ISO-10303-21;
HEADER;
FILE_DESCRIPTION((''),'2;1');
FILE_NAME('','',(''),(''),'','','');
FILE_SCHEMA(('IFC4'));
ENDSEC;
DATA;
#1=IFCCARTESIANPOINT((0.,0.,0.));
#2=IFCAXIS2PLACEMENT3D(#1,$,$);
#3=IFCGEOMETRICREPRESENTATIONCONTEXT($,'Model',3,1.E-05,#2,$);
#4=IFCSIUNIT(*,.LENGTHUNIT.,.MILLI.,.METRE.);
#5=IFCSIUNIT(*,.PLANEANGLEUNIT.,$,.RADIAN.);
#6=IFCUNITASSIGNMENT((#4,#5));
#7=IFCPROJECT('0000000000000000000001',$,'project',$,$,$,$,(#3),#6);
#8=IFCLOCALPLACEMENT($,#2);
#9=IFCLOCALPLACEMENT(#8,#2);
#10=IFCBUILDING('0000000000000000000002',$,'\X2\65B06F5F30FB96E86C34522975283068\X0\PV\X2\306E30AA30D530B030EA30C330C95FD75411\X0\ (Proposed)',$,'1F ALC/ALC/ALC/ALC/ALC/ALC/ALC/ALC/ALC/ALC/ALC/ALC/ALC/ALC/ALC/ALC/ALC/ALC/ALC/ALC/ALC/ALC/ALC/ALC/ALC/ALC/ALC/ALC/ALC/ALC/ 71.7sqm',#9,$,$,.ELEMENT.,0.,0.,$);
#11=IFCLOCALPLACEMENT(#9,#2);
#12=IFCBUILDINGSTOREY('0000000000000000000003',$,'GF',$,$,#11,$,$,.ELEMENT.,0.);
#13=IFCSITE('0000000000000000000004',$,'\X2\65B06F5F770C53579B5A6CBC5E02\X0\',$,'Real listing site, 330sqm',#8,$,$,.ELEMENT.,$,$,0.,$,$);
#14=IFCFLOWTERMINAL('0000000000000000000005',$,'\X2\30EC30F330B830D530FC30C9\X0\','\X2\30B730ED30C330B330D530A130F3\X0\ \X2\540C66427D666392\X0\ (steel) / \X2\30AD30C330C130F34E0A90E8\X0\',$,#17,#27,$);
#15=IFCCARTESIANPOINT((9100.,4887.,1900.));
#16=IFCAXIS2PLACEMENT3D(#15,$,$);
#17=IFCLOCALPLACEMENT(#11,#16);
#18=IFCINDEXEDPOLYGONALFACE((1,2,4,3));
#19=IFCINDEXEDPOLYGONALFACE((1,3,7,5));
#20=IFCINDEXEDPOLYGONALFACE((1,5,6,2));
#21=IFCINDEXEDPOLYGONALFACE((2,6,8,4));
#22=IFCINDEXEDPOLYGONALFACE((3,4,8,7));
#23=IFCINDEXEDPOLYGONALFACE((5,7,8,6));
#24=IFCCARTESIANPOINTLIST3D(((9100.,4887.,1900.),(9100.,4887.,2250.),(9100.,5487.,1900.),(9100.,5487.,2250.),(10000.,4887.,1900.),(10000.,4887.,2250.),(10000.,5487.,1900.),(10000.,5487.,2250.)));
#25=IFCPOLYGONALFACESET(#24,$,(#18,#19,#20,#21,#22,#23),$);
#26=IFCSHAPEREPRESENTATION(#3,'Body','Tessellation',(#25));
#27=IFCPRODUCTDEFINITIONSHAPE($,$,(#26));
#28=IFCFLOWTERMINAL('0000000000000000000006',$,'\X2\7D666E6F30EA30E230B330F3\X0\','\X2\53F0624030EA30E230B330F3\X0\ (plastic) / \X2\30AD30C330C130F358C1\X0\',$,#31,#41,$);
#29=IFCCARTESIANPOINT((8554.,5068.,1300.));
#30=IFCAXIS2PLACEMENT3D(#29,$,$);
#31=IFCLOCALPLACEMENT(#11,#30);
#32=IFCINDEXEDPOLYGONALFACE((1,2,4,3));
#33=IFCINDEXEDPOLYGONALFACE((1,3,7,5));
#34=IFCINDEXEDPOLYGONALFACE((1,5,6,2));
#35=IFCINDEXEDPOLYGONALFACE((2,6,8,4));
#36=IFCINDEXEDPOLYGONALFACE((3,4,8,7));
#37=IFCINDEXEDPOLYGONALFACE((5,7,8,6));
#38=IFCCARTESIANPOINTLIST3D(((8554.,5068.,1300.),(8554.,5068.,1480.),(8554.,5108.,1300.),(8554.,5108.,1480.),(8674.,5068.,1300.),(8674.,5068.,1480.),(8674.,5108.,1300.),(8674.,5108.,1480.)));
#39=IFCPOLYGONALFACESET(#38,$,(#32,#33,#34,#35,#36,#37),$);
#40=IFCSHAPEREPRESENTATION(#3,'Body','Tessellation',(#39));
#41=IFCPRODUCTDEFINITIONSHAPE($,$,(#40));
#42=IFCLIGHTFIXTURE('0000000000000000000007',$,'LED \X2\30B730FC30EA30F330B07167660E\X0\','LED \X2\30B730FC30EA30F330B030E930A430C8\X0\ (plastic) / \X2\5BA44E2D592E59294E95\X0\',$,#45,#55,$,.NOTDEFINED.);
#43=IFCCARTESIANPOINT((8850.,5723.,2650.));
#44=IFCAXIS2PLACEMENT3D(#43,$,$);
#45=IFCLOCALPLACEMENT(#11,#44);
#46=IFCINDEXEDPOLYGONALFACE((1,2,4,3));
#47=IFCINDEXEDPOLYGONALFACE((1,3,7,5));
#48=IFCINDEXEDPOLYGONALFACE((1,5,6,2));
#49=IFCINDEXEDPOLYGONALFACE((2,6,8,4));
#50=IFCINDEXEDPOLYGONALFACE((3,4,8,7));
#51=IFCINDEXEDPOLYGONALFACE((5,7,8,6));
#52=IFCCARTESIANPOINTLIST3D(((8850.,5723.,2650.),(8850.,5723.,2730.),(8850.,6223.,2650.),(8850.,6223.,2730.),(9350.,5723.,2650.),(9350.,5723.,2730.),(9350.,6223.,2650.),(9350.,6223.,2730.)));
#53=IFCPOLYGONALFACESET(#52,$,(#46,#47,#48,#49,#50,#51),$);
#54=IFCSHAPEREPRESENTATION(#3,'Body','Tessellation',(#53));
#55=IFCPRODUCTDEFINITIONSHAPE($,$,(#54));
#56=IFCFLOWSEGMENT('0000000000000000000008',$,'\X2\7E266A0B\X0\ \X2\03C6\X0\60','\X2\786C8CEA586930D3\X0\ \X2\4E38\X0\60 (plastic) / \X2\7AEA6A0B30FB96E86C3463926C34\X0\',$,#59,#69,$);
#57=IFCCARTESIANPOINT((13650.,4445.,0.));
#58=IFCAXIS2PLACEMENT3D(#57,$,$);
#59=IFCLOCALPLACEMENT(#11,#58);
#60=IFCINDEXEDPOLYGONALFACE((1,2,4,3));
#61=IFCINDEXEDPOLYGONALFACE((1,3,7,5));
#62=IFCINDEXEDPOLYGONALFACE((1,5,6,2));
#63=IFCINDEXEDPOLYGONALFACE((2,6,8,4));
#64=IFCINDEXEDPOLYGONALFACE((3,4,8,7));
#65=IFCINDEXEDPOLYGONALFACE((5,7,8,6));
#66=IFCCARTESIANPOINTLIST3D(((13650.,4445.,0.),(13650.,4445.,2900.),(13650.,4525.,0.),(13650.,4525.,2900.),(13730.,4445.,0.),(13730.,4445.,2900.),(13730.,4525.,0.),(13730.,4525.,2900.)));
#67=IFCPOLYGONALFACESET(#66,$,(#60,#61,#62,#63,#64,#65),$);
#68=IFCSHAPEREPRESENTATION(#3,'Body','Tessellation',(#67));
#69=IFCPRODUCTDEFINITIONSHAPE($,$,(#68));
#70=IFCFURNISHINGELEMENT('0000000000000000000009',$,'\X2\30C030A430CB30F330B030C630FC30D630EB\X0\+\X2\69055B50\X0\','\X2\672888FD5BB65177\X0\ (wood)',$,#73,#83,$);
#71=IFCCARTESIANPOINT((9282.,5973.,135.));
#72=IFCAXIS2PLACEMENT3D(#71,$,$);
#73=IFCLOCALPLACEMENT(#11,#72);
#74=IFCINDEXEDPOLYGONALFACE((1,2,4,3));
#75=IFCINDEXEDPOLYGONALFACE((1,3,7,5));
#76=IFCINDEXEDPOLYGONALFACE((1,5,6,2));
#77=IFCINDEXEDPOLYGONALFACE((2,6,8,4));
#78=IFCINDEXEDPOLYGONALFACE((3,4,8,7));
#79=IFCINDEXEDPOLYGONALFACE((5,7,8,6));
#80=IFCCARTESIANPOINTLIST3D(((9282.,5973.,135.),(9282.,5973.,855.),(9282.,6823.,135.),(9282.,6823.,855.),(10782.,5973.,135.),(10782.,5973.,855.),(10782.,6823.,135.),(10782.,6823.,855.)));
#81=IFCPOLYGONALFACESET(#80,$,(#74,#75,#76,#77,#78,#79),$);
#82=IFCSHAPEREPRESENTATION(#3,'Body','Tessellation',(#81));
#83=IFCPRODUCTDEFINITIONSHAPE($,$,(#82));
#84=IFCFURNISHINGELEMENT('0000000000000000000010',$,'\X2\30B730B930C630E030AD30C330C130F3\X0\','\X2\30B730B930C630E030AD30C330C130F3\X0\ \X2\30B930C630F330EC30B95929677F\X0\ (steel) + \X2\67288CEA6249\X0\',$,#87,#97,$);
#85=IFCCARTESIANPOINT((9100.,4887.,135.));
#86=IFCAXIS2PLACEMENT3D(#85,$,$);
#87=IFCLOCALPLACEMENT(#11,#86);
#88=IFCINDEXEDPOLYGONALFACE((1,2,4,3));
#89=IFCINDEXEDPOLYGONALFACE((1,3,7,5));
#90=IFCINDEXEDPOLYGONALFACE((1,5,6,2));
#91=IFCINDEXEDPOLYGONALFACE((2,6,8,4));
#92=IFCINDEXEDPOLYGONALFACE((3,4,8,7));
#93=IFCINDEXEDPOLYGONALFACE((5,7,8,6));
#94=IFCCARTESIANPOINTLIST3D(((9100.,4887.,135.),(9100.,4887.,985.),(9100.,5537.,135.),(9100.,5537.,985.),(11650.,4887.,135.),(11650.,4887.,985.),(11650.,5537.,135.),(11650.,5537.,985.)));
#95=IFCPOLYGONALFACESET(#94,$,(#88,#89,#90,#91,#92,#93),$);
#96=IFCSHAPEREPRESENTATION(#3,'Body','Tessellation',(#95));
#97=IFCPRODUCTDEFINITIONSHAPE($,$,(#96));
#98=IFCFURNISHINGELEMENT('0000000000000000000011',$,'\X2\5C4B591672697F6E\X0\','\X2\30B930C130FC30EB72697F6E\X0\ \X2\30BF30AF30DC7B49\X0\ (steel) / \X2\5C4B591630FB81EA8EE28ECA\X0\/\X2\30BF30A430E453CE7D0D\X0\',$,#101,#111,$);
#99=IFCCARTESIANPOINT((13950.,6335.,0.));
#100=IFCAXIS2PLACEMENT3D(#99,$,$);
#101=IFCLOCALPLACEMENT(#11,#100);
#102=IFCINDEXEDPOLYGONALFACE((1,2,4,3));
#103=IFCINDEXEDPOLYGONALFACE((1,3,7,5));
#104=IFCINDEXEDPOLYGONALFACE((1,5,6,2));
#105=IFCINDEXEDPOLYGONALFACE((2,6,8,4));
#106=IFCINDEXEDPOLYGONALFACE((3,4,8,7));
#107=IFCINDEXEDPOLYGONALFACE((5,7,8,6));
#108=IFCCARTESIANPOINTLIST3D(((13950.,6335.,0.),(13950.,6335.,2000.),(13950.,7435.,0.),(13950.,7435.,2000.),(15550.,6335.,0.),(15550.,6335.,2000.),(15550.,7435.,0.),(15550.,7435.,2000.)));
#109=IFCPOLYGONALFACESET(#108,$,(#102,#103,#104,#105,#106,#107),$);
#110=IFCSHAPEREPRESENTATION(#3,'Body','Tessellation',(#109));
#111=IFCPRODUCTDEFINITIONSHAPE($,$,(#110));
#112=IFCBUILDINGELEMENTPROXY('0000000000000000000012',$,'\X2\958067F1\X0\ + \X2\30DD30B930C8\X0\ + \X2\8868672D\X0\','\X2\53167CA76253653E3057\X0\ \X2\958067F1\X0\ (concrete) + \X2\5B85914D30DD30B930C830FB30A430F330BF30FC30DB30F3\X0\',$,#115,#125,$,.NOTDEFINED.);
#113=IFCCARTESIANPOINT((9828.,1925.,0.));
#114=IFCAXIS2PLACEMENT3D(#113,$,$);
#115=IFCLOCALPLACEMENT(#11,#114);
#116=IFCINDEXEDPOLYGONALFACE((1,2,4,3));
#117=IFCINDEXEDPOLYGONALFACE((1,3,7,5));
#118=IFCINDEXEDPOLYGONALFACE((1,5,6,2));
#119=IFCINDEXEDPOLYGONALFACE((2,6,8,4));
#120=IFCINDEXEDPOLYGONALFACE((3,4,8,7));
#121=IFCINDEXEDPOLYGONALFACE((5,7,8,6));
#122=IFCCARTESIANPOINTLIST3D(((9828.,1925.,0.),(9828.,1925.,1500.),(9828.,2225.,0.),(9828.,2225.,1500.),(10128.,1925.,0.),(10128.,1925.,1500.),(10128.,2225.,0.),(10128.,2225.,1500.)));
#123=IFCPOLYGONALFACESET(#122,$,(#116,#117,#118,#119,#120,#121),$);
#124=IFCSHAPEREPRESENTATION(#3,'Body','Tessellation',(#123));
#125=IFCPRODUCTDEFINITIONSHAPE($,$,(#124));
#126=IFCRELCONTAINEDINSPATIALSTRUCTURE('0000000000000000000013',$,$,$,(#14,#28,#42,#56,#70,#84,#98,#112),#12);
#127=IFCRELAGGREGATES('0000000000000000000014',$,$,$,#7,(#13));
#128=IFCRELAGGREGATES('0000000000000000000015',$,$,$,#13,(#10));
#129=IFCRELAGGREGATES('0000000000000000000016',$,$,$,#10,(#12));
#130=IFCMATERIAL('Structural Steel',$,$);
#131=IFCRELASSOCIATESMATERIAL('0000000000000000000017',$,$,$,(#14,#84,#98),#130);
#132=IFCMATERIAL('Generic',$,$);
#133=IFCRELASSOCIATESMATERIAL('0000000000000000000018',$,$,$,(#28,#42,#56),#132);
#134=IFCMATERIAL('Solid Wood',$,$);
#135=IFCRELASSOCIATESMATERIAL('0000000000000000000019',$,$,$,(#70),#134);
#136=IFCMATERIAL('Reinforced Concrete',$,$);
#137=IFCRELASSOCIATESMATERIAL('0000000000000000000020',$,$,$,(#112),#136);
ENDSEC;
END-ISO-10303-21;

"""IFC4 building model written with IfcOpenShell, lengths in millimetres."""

from ifc_helpers import new_model, si_unit, frame, frame_2d, origin, place, context, project, spatial, rectangle, extrude, material, element, save


model = new_model("IFC4")

# Units and contexts
model_context = context("Model", 3, precision=1e-05, world=origin())
ifc_project = project(units=[si_unit("LENGTHUNIT", "METRE", prefix="MILLI"), si_unit("PLANEANGLEUNIT", "RADIAN")], contexts=[model_context])

# Site, building, storey
site_placement = place(None, origin())
site = spatial("IfcSite", under=ifc_project, at=site_placement, Name="新潟県南魚沼市", ObjectType="Real listing site, 330sqm", CompositionType="ELEMENT", RefElevation=0.0)
building_placement = place(site_placement, origin())
building = spatial("IfcBuilding", under=site, at=building_placement, Name="新潟・雨水利用とPVのオフグリッド志向 (Proposed)", ObjectType="1F ALC/ALC/ALC/ALC/ALC/ALC/ALC/ALC/ALC/ALC/ALC/ALC/ALC/ALC/ALC/ALC/ALC/ALC/ALC/ALC/ALC/ALC/ALC/ALC/ALC/ALC/ALC/ALC/ALC/ALC/ 71.7sqm", CompositionType="ELEMENT", ElevationOfRefHeight=0.0, ElevationOfTerrain=0.0)
storey_placement = place(building_placement, origin())
storey = spatial("IfcBuildingStorey", under=building, at=storey_placement, Name="GF", CompositionType="ELEMENT", Elevation=0.0)

# Shared definitions
ifc_material_1 = material(Name="Solid Wood")

# Shared definitions
ifc_material_2 = material(Name="Structural Steel")

# Shared definitions
ifc_material_3 = material(Name="Reinforced Concrete")

# Flow terminals
flow_terminal_1_placement = place(storey_placement, frame((9100.0, 4887.0, 1900.0)))
element("IfcFlowTerminal", 1, at=flow_terminal_1_placement, inside=storey, material=ifc_material_2, Name="レンジフード", Description="シロッコファン 同時給排 (steel) / キッチン上部", context=model_context, shape_type="SweptSolid", body=[
    extrude(rectangle(XDim=900.0, YDim=600.0, at=frame_2d((450.0, 300.0))), frame((9100.0, 4887.0, 1900.0)), (0.0, 0.0, 1.0), 350.0),
])
ifc_material_4 = material(Name="Generic")
flow_terminal_2_placement = place(storey_placement, frame((8554.0, 5068.0, 1300.0)))
element("IfcFlowTerminal", 2, at=flow_terminal_2_placement, inside=storey, material=ifc_material_4, Name="給湯リモコン", Description="台所リモコン (plastic) / キッチン壁", context=model_context, shape_type="SweptSolid", body=[
    extrude(rectangle(XDim=120.0, YDim=40.0, at=frame_2d((60.0, 20.0))), frame((8554.0, 5068.0, 1300.0)), (0.0, 0.0, 1.0), 180.0),
])

# Light fixture
light_fixture_placement = place(storey_placement, frame((8850.0, 5723.0, 2650.0)))
element("IfcLightFixture", 3, at=light_fixture_placement, inside=storey, material=ifc_material_4, Name="LED シーリング照明", Description="LED シーリングライト (plastic) / 室中央天井", PredefinedType="NOTDEFINED", context=model_context, shape_type="SweptSolid", body=[
    extrude(rectangle(XDim=500.0, YDim=500.0, at=frame_2d((250.0, 250.0))), frame((8850.0, 5723.0, 2650.0)), (0.0, 0.0, 1.0), 80.0),
])

# Flow segment
flow_segment_placement = place(storey_placement, frame((13650.0, 4445.0, 0.0)))
element("IfcFlowSegment", 4, at=flow_segment_placement, inside=storey, material=ifc_material_4, Name="縦樋 φ60", Description="硬質塩ビ 丸60 (plastic) / 竪樋・雨水排水", context=model_context, shape_type="SweptSolid", body=[
    extrude(rectangle(XDim=80.0, YDim=80.0, at=frame_2d((40.0, 40.0))), frame((13650.0, 4445.0, 0.0)), (0.0, 0.0, 1.0), 2900.0),
])

# Furnishing elements
furnishing_1_placement = place(storey_placement, frame((9282.0, 5973.0, 135.0)))
element("IfcFurnishingElement", 5, at=furnishing_1_placement, inside=storey, material=ifc_material_1, Name="ダイニングテーブル+椅子", Description="木製家具 (wood)", context=model_context, shape_type="SweptSolid", body=[
    extrude(rectangle(XDim=1500.0, YDim=850.0, at=frame_2d((750.0, 425.0))), frame((9282.0, 5973.0, 135.0)), (0.0, 0.0, 1.0), 720.0),
])
furnishing_2_placement = place(storey_placement, frame((9100.0, 4887.0, 135.0)))
element("IfcFurnishingElement", 6, at=furnishing_2_placement, inside=storey, material=ifc_material_2, Name="システムキッチン", Description="システムキッチン ステンレス天板 (steel) + 木質扉", context=model_context, shape_type="SweptSolid", body=[
    extrude(rectangle(XDim=2550.0, YDim=650.0, at=frame_2d((1275.0, 325.0))), frame((9100.0, 4887.0, 135.0)), (0.0, 0.0, 1.0), 850.0),
])
furnishing_3_placement = place(storey_placement, frame((13950.0, 6335.0, 0.0)))
element("IfcFurnishingElement", 7, at=furnishing_3_placement, inside=storey, material=ifc_material_2, Name="屋外物置", Description="スチール物置 タクボ等 (steel) / 屋外・自転車/タイヤ収納", context=model_context, shape_type="SweptSolid", body=[
    extrude(rectangle(XDim=1600.0, YDim=1100.0, at=frame_2d((800.0, 550.0))), frame((13950.0, 6335.0, 0.0)), (0.0, 0.0, 1.0), 2000.0),
])

# Building element proxy
proxy_placement = place(storey_placement, frame((9828.0, 1925.0, 0.0)))
element("IfcBuildingElementProxy", 8, at=proxy_placement, inside=storey, material=ifc_material_3, Name="門柱 + ポスト + 表札", Description="化粧打放し 門柱 (concrete) + 宅配ポスト・インターホン", PredefinedType="NOTDEFINED", context=model_context, shape_type="SweptSolid", body=[
    extrude(rectangle(XDim=300.0, YDim=300.0, at=frame_2d((150.0, 150.0))), frame((9828.0, 1925.0, 0.0)), (0.0, 0.0, 1.0), 1500.0),
])

save(model, "model.ifc")
